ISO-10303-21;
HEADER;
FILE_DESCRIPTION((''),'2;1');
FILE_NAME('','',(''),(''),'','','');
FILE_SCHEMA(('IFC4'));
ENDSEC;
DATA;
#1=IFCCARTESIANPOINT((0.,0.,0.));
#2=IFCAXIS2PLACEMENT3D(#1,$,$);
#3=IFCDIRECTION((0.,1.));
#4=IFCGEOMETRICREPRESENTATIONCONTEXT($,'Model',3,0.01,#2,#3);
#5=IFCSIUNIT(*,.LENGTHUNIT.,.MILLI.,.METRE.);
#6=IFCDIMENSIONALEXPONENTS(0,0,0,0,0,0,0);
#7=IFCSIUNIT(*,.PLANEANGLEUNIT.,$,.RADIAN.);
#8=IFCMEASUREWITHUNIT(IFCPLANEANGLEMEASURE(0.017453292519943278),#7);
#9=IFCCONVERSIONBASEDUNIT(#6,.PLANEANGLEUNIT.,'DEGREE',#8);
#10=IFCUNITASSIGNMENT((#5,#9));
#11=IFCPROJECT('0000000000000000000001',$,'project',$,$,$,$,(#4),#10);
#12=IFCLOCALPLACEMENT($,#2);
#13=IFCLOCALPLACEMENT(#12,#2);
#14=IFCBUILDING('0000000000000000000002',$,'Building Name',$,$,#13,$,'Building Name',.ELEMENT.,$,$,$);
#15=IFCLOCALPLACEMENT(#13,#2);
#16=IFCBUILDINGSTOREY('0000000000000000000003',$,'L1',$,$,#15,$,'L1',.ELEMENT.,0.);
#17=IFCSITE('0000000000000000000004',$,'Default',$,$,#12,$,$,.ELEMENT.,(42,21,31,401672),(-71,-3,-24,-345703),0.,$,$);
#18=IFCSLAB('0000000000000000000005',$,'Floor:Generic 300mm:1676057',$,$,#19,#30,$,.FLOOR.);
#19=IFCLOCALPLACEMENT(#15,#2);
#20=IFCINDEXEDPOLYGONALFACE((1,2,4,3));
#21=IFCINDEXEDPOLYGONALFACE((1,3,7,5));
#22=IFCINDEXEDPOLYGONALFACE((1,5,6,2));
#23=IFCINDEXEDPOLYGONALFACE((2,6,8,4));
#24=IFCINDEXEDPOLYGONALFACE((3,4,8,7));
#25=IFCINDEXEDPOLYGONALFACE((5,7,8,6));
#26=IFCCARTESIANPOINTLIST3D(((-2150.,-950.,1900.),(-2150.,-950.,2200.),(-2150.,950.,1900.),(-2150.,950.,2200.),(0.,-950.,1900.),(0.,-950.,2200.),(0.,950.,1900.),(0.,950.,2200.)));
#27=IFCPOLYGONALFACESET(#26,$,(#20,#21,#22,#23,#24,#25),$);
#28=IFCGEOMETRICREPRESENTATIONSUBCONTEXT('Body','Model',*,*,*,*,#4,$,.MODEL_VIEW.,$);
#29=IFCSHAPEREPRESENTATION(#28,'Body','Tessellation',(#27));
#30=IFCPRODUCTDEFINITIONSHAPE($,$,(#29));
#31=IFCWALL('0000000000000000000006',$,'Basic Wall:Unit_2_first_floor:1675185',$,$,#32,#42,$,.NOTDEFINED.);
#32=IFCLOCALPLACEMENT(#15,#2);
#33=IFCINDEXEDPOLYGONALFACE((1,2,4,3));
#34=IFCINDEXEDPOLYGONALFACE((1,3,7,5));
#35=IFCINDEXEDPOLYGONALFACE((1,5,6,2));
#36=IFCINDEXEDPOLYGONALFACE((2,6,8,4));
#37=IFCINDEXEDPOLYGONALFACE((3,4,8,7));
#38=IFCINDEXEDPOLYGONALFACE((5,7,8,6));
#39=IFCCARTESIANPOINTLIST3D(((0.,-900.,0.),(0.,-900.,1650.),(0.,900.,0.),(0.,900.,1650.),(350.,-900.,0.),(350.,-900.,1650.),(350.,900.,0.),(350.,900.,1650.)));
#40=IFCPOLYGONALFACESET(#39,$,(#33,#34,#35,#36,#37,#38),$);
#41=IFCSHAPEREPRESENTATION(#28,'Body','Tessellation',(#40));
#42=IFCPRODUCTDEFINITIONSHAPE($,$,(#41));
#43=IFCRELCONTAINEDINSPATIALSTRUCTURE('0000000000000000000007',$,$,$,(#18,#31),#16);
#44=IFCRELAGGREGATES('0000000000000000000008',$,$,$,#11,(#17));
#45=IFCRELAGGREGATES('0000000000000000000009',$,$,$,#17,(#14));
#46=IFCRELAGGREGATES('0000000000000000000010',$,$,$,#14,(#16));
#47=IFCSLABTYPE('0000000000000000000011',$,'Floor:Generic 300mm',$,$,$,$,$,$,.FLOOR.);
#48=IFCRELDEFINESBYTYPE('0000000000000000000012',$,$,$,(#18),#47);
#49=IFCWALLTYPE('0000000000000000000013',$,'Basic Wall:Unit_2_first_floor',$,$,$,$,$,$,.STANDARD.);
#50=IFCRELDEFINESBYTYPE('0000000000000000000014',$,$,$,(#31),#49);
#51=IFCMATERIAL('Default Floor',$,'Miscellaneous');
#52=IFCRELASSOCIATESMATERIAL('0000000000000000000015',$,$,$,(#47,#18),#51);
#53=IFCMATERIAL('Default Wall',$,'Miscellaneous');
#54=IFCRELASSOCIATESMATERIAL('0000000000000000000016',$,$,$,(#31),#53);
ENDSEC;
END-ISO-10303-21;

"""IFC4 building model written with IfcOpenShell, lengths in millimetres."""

from ifc_helpers import new_model, entity, si_unit, converted_unit, direction, frame, origin, place, context, subcontext, project, spatial, indexed_curve, outline, extrude, material, type_object, element, save


model = new_model("IFC4")

# Units and contexts
model_context = context("Model", 3, precision=0.01, world=origin(), true_north=direction((0.0, 1.0)))
body_context = subcontext(model_context, "Body", "Model", "MODEL_VIEW")
ifc_project = project(units=[si_unit("LENGTHUNIT", "METRE", prefix="MILLI"), converted_unit("PLANEANGLEUNIT", "DEGREE", entity("IfcPlaneAngleMeasure", 0.017453292519943278), si_unit("PLANEANGLEUNIT", "RADIAN"), dimensions=[0, 0, 0, 0, 0, 0, 0])], contexts=[model_context])

# Site, building, storey
site_placement = place(None, origin())
site = spatial("IfcSite", under=ifc_project, at=site_placement, Name="Default", CompositionType="ELEMENT", RefLatitude=(42, 21, 31, 401672), RefLongitude=(-71, -3, -24, -345703), RefElevation=0.0)
building_placement = place(site_placement, origin())
building = spatial("IfcBuilding", under=site, at=building_placement, Name="Building Name", LongName="Building Name", CompositionType="ELEMENT")
storey_placement = place(building_placement, origin())
storey = spatial("IfcBuildingStorey", under=building, at=storey_placement, Name="L1", LongName="L1", CompositionType="ELEMENT", Elevation=0.0)

# Slab
ifc_material_1 = material(Name="Default Floor", Category="Miscellaneous")
slab_type = type_object("IfcSlabType", Name="Floor:Generic 300mm", PredefinedType="FLOOR", material=ifc_material_1)
slab_placement = place(storey_placement, origin())
element("IfcSlab", 1, at=slab_placement, inside=storey, type_object=slab_type, material=ifc_material_1, Name="Floor:Generic 300mm:1676057", PredefinedType="FLOOR", context=body_context, shape_type="SweptSolid", body=[
    extrude(outline(indexed_curve([(-950.0, -1075.0), (950.0, -1075.0), (950.0, 1075.0), (-950.0, 1075.0), (-950.0, -1075.0)], self_intersect=False)), frame((-1075.0, 0.0, 2200.0), z_axis=(0.0, 0.0, -1.0), x_axis=(0.0, 1.0, 0.0)), (0.0, 0.0, 1.0), 300.0),
])

# Wall
ifc_material_2 = material(Name="Default Wall", Category="Miscellaneous")
wall_type = type_object("IfcWallType", Name="Basic Wall:Unit_2_first_floor", PredefinedType="STANDARD")
wall_placement = place(storey_placement, frame((175.0, -900.0, 0.0), z_axis=(0.0, 0.0, 1.0), x_axis=(0.0, 1.0, 0.0)))
element("IfcWall", 2, at=wall_placement, inside=storey, type_object=wall_type, material=ifc_material_2, Name="Basic Wall:Unit_2_first_floor:1675185", PredefinedType="NOTDEFINED", context=body_context, shape_type="SweptSolid", body=[
    extrude(outline(indexed_curve([(1800.0, 175.0), (0.0, 175.0), (0.0, -175.0), (1800.0, -175.0), (1800.0, 175.0)], self_intersect=False)), origin(), (0.0, 0.0, 1.0), 1650.0),
])

save(model, "model.ifc")
